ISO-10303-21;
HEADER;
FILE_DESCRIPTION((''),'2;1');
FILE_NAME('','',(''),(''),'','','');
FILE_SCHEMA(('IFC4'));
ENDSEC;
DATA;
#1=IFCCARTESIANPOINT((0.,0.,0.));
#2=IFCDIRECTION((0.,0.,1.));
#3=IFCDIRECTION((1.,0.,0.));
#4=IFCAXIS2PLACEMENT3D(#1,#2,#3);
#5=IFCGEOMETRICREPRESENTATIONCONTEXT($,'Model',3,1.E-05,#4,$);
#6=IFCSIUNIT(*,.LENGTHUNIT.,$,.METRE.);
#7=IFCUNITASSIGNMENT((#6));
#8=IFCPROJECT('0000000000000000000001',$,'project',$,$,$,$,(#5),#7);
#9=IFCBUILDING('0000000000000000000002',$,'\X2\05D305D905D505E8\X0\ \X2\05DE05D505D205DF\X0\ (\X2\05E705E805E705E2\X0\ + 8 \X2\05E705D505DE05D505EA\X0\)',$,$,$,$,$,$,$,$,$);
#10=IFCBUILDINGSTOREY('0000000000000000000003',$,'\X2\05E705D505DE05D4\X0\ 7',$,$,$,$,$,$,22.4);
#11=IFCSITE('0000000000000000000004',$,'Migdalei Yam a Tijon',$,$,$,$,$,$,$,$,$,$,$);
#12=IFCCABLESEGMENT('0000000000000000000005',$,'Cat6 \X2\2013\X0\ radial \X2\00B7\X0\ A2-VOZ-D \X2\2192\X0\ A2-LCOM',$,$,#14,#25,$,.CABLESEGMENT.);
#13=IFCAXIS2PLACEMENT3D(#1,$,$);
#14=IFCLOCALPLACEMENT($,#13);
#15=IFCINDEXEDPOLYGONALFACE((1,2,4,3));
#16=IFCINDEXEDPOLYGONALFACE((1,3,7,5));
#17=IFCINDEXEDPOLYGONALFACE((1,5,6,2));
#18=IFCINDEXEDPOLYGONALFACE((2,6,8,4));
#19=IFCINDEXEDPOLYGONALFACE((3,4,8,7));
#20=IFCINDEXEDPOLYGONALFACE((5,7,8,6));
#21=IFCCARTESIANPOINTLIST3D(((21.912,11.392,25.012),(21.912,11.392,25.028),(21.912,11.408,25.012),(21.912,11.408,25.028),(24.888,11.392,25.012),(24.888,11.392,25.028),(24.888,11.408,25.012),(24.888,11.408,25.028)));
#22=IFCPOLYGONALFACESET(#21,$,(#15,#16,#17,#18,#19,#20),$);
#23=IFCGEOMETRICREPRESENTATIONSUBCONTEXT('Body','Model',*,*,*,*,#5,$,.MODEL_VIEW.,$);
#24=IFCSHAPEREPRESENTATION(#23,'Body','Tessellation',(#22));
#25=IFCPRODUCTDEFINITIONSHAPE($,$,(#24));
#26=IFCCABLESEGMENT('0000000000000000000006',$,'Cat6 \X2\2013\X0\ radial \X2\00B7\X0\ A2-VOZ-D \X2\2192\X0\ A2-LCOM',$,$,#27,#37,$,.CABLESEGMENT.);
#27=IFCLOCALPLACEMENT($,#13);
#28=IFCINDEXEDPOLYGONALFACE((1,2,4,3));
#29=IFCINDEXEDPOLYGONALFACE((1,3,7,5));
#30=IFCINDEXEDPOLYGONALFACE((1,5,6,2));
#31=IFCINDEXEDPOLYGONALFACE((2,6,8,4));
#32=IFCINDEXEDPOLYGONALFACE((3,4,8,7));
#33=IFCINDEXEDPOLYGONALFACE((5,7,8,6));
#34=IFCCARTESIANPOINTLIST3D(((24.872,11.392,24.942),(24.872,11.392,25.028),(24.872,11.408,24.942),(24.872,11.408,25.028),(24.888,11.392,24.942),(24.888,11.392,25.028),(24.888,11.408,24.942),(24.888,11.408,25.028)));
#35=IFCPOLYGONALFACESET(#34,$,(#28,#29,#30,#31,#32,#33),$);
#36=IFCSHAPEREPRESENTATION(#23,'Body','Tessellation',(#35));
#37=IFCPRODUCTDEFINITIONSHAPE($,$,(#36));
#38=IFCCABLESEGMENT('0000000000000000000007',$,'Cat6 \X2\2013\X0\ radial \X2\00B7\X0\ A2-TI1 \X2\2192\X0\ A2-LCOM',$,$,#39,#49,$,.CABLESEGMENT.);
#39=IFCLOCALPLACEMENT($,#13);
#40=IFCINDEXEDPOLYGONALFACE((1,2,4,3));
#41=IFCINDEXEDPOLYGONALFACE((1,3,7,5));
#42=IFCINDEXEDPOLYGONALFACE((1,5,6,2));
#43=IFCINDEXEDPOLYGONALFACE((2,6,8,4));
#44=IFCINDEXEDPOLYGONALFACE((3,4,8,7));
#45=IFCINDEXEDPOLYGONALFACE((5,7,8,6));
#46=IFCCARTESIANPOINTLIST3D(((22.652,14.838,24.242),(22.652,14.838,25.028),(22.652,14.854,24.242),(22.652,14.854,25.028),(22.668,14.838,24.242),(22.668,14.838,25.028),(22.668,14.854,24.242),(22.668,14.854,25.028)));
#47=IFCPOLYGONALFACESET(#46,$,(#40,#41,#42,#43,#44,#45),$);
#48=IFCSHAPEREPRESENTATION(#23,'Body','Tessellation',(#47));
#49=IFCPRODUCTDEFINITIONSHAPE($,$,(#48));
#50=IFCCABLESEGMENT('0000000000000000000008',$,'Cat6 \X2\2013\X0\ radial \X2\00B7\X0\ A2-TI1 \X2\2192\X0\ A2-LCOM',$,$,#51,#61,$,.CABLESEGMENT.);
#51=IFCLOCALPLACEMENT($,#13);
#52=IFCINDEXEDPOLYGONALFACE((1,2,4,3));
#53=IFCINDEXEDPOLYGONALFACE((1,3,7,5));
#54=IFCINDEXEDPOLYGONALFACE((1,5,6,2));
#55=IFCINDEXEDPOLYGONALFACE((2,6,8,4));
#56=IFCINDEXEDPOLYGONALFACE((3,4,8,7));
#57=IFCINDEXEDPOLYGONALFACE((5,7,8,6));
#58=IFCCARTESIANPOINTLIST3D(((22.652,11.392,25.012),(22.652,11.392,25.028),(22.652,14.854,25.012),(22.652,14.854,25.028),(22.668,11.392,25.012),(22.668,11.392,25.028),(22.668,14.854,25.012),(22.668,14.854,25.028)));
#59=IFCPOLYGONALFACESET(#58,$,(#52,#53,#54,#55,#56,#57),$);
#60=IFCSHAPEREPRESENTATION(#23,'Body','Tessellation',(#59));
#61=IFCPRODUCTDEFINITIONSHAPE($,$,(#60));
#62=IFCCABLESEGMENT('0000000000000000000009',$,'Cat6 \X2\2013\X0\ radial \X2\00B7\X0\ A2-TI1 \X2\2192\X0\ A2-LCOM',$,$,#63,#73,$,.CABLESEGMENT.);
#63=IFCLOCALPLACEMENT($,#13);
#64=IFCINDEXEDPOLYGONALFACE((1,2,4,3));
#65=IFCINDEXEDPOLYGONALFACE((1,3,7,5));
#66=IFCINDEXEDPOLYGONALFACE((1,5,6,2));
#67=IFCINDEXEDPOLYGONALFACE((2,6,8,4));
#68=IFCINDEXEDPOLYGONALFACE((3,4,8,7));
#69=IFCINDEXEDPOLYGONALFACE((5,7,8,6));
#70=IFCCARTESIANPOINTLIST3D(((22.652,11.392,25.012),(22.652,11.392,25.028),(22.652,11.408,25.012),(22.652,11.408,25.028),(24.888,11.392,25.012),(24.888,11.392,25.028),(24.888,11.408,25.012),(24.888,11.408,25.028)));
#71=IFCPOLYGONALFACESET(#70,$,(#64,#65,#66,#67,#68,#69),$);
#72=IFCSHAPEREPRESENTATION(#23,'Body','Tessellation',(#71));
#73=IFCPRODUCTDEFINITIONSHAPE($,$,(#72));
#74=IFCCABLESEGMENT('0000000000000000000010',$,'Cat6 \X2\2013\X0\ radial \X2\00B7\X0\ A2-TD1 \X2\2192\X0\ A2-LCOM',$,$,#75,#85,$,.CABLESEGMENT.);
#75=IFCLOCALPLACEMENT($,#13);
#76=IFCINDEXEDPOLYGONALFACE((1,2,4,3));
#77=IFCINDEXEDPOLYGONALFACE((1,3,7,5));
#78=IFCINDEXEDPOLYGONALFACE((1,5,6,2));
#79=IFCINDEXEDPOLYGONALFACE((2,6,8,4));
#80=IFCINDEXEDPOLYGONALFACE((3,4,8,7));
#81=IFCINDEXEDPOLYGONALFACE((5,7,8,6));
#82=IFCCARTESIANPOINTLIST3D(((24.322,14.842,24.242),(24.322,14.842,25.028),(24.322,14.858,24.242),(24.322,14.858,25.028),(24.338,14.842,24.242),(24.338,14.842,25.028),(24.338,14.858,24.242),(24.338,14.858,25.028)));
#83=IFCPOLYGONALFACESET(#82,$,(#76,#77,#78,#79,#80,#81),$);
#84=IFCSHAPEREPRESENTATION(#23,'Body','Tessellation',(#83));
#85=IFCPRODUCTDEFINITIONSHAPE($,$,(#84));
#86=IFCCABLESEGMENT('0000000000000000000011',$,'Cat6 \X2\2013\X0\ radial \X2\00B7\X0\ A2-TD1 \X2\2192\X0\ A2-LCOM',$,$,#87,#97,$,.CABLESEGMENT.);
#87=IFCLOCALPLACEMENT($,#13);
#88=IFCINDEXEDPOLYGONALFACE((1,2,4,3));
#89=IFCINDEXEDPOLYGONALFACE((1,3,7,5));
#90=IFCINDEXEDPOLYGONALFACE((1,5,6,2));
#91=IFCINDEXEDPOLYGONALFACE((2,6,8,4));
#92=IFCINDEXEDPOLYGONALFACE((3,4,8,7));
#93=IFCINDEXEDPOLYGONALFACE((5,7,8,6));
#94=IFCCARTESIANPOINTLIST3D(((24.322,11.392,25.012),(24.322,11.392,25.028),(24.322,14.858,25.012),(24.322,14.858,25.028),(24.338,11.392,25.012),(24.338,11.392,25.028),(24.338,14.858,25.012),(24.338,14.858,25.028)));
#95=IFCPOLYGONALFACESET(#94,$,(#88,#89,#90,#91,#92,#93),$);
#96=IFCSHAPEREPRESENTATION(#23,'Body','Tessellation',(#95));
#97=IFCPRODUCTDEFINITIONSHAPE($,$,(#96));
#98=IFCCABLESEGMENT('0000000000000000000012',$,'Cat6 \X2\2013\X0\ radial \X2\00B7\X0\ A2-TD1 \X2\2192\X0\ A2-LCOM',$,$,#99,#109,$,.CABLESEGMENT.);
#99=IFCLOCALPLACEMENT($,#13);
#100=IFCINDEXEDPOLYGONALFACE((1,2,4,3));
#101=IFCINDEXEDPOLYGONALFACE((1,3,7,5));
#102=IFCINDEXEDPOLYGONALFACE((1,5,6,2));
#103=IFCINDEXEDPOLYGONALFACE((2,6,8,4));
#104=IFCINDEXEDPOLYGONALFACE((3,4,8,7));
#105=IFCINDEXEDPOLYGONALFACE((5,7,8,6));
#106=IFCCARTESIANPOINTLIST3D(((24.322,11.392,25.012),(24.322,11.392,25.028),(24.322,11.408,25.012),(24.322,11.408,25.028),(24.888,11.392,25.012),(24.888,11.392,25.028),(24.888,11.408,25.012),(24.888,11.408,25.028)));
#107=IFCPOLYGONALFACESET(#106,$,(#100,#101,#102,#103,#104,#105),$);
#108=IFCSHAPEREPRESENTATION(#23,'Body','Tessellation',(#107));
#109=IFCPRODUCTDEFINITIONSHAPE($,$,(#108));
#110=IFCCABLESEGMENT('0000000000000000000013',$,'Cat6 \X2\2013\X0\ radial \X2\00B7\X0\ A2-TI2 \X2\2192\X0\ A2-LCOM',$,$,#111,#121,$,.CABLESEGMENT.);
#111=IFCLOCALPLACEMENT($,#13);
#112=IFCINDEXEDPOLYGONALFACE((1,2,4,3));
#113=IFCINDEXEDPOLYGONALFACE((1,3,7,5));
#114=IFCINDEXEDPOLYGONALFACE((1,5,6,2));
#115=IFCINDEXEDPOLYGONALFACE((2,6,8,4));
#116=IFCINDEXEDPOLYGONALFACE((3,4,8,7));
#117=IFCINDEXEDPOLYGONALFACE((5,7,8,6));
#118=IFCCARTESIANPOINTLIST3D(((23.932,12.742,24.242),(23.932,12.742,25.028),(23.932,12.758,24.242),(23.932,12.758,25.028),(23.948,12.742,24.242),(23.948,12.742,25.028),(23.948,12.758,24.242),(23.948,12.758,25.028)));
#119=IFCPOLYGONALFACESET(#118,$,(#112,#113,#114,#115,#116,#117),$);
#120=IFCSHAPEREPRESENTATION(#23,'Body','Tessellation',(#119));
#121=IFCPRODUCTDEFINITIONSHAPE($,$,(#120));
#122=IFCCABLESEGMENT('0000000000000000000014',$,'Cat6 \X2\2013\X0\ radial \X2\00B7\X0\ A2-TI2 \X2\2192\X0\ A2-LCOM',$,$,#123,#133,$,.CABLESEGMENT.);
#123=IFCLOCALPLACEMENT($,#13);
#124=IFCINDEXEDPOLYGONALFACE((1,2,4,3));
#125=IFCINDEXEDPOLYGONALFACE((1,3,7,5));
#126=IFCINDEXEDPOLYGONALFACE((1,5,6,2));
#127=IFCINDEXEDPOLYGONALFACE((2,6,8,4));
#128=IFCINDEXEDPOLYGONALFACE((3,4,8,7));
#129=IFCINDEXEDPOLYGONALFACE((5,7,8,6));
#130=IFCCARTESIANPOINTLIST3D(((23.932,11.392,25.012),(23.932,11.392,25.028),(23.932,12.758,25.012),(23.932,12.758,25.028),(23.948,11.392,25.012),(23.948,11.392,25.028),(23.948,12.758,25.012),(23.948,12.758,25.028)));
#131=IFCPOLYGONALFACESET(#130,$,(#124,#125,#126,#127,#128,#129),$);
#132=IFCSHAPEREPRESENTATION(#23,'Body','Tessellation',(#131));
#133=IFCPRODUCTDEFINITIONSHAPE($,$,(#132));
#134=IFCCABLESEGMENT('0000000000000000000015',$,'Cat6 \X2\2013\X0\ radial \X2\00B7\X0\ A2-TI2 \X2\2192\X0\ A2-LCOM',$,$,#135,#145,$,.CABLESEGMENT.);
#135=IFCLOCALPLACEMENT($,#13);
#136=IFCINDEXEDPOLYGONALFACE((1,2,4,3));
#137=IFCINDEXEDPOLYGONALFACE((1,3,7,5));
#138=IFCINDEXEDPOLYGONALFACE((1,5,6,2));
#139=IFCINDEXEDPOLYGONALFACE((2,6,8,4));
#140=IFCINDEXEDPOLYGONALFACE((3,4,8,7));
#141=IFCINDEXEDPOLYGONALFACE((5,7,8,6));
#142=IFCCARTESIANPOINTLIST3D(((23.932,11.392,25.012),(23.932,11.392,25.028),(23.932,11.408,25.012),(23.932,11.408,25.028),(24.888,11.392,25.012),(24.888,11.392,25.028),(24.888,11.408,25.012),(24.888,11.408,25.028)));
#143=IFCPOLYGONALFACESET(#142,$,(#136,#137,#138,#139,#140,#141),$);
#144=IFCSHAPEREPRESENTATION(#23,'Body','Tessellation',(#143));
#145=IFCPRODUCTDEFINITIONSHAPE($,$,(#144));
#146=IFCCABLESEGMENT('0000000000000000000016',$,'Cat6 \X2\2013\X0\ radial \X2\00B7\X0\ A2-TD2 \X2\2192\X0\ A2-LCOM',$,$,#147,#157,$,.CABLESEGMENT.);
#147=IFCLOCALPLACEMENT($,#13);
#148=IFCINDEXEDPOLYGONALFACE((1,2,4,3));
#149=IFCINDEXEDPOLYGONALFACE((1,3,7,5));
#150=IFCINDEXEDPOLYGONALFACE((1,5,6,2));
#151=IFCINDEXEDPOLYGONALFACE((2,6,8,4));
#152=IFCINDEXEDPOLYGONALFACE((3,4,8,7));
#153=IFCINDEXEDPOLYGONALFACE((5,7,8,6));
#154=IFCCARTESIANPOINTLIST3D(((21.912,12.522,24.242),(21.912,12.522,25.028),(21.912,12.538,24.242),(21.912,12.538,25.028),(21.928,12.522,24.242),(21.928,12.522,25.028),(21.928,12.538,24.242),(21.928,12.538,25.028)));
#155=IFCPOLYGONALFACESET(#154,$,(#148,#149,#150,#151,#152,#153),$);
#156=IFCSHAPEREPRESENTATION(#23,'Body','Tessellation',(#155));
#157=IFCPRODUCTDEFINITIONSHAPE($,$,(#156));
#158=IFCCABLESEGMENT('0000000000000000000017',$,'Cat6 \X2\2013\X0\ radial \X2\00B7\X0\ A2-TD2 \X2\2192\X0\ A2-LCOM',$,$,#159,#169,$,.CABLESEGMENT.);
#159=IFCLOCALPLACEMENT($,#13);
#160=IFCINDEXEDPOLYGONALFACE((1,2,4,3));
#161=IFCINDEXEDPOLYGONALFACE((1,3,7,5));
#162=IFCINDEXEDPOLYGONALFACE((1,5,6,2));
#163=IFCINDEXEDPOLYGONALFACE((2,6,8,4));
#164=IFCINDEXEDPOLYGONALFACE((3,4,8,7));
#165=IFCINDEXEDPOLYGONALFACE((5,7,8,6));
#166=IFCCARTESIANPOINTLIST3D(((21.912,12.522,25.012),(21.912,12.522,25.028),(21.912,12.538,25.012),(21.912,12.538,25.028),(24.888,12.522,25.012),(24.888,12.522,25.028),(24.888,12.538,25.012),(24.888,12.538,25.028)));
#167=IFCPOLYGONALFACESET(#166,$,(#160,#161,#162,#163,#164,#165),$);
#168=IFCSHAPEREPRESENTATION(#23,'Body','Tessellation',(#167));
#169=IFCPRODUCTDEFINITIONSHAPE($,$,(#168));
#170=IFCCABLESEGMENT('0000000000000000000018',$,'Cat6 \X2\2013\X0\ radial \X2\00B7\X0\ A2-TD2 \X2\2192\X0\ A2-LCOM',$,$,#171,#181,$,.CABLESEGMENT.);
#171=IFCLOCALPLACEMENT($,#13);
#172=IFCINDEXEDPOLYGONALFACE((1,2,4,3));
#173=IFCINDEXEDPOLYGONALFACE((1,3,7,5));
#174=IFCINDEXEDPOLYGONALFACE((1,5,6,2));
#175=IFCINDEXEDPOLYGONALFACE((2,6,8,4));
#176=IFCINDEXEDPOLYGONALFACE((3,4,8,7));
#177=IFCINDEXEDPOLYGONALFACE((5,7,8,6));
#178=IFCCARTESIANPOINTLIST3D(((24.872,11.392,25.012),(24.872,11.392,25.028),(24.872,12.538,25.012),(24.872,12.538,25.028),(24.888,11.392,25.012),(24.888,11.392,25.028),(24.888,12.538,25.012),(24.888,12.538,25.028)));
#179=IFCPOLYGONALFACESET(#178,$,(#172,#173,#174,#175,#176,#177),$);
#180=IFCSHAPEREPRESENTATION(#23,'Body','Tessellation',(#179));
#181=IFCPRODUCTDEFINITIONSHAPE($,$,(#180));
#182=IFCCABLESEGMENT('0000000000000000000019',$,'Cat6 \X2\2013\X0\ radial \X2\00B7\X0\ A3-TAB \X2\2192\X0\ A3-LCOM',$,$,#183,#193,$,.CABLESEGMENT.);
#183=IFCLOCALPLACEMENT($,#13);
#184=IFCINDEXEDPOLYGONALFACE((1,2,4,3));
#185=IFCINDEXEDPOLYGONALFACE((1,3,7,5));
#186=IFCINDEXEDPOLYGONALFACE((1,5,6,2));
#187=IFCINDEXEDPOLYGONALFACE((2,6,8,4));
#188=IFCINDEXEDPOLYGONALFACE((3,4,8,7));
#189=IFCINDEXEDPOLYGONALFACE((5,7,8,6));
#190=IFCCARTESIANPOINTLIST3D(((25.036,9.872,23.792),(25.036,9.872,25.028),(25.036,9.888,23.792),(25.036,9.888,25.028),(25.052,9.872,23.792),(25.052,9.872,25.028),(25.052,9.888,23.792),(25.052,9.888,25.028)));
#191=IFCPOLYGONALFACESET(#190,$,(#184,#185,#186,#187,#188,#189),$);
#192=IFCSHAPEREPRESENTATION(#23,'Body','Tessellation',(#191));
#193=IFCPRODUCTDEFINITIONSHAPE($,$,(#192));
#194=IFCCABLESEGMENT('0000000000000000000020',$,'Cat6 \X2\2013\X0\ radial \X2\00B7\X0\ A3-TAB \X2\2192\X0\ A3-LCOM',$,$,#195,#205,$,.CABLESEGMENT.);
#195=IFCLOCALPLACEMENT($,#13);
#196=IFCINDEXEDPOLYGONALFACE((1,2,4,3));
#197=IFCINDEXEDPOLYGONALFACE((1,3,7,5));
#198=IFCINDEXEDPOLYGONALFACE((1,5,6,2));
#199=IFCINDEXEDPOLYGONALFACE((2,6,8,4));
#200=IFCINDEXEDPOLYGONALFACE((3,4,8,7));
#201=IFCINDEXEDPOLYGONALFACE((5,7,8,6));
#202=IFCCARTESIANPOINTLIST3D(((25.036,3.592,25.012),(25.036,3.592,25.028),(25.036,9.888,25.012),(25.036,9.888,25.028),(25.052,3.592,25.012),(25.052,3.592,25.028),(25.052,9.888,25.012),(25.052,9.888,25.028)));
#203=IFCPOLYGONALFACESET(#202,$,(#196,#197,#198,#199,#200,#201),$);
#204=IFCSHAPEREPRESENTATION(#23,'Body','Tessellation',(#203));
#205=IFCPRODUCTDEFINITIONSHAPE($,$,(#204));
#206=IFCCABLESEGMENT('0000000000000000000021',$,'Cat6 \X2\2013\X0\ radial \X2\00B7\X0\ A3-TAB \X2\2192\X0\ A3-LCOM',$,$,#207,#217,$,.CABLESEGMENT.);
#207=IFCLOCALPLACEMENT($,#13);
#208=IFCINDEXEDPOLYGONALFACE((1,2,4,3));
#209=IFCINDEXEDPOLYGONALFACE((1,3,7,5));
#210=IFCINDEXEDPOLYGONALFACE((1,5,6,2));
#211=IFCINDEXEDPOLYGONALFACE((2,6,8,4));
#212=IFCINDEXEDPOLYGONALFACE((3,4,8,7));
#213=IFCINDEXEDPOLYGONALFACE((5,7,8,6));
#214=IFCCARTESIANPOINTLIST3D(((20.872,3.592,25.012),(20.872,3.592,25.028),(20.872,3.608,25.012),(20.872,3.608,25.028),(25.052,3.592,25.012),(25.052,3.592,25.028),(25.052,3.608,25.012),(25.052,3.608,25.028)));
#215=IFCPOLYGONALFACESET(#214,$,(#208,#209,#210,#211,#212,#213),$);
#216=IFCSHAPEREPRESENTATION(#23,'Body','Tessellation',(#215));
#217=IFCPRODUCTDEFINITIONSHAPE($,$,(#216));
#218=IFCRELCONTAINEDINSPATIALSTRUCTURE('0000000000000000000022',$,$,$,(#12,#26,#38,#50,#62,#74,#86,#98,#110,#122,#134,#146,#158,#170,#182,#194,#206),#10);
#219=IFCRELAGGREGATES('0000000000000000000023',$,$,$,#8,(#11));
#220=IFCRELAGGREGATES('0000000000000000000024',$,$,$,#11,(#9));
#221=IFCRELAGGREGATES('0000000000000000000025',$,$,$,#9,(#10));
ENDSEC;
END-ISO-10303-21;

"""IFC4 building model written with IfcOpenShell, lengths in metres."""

from ifc_helpers import new_model, si_unit, frame, origin_with_axes, context, subcontext, project, spatial, line, indexed_curve, outline, extrude, element, save


model = new_model("IFC4")

# Units and contexts
model_context = context("Model", 3, precision=1e-05, world=origin_with_axes())
body_context = subcontext(model_context, "Body", "Model", "MODEL_VIEW")
ifc_project = project(units=[si_unit("LENGTHUNIT", "METRE")], contexts=[model_context])

# Site, building, storey
site = spatial("IfcSite", under=ifc_project, Name="Migdalei Yam a Tijon")
building = spatial("IfcBuilding", under=site, Name="דיור מוגן (קרקע + 8 קומות)")
storey = spatial("IfcBuildingStorey", under=building, Name="קומה 7", Elevation=22.4)

# Cable segments
element("IfcCableSegment", 1, inside=storey, Name="Cat6 – radial · A2-VOZ-D → A2-LCOM", PredefinedType="CABLESEGMENT", context=body_context, shape_type="SweptSolid", body=[
    extrude(outline(indexed_curve([(0.0, 0.0), (2.976, 0.0), (2.976, 0.016), (0.0, 0.016)], segments=[line(1, 2, 3, 4, 1)])), frame((21.912, 11.392, 25.012), z_axis=(0.0, 0.0, 1.0), x_axis=(1.0, 0.0, 0.0)), (0.0, 0.0, 1.0), 0.016),
])
element("IfcCableSegment", 2, inside=storey, Name="Cat6 – radial · A2-VOZ-D → A2-LCOM", PredefinedType="CABLESEGMENT", context=body_context, shape_type="SweptSolid", body=[
    extrude(outline(indexed_curve([(0.0, 0.0), (0.016, 0.0), (0.016, 0.016), (0.0, 0.016)], segments=[line(1, 2, 3, 4, 1)])), frame((24.872, 11.392, 24.942), z_axis=(0.0, 0.0, 1.0), x_axis=(1.0, 0.0, 0.0)), (0.0, 0.0, 1.0), 0.086),
])
element("IfcCableSegment", 3, inside=storey, Name="Cat6 – radial · A2-TI1 → A2-LCOM", PredefinedType="CABLESEGMENT", context=body_context, shape_type="SweptSolid", body=[
    extrude(outline(indexed_curve([(0.0, 0.0), (0.016, 0.0), (0.016, 0.016), (0.0, 0.016)], segments=[line(1, 2, 3, 4, 1)])), frame((22.652, 14.838, 24.242), z_axis=(0.0, 0.0, 1.0), x_axis=(1.0, 0.0, 0.0)), (0.0, 0.0, 1.0), 0.786),
])
element("IfcCableSegment", 4, inside=storey, Name="Cat6 – radial · A2-TI1 → A2-LCOM", PredefinedType="CABLESEGMENT", context=body_context, shape_type="SweptSolid", body=[
    extrude(outline(indexed_curve([(0.0, 0.0), (0.016, 0.0), (0.016, 3.462), (0.0, 3.462)], segments=[line(1, 2, 3, 4, 1)])), frame((22.652, 11.392, 25.012), z_axis=(0.0, 0.0, 1.0), x_axis=(1.0, 0.0, 0.0)), (0.0, 0.0, 1.0), 0.016),
])
element("IfcCableSegment", 5, inside=storey, Name="Cat6 – radial · A2-TI1 → A2-LCOM", PredefinedType="CABLESEGMENT", context=body_context, shape_type="SweptSolid", body=[
    extrude(outline(indexed_curve([(0.0, 0.0), (2.236, 0.0), (2.236, 0.016), (0.0, 0.016)], segments=[line(1, 2, 3, 4, 1)])), frame((22.652, 11.392, 25.012), z_axis=(0.0, 0.0, 1.0), x_axis=(1.0, 0.0, 0.0)), (0.0, 0.0, 1.0), 0.016),
])
element("IfcCableSegment", 6, inside=storey, Name="Cat6 – radial · A2-TD1 → A2-LCOM", PredefinedType="CABLESEGMENT", context=body_context, shape_type="SweptSolid", body=[
    extrude(outline(indexed_curve([(0.0, 0.0), (0.016, 0.0), (0.016, 0.016), (0.0, 0.016)], segments=[line(1, 2, 3, 4, 1)])), frame((24.322, 14.842, 24.242), z_axis=(0.0, 0.0, 1.0), x_axis=(1.0, 0.0, 0.0)), (0.0, 0.0, 1.0), 0.786),
])
element("IfcCableSegment", 7, inside=storey, Name="Cat6 – radial · A2-TD1 → A2-LCOM", PredefinedType="CABLESEGMENT", context=body_context, shape_type="SweptSolid", body=[
    extrude(outline(indexed_curve([(0.0, 0.0), (0.016, 0.0), (0.016, 3.466), (0.0, 3.466)], segments=[line(1, 2, 3, 4, 1)])), frame((24.322, 11.392, 25.012), z_axis=(0.0, 0.0, 1.0), x_axis=(1.0, 0.0, 0.0)), (0.0, 0.0, 1.0), 0.016),
])
element("IfcCableSegment", 8, inside=storey, Name="Cat6 – radial · A2-TD1 → A2-LCOM", PredefinedType="CABLESEGMENT", context=body_context, shape_type="SweptSolid", body=[
    extrude(outline(indexed_curve([(0.0, 0.0), (0.566, 0.0), (0.566, 0.016), (0.0, 0.016)], segments=[line(1, 2, 3, 4, 1)])), frame((24.322, 11.392, 25.012), z_axis=(0.0, 0.0, 1.0), x_axis=(1.0, 0.0, 0.0)), (0.0, 0.0, 1.0), 0.016),
])
element("IfcCableSegment", 9, inside=storey, Name="Cat6 – radial · A2-TI2 → A2-LCOM", PredefinedType="CABLESEGMENT", context=body_context, shape_type="SweptSolid", body=[
    extrude(outline(indexed_curve([(0.0, 0.0), (0.016, 0.0), (0.016, 0.016), (0.0, 0.016)], segments=[line(1, 2, 3, 4, 1)])), frame((23.932, 12.742, 24.242), z_axis=(0.0, 0.0, 1.0), x_axis=(1.0, 0.0, 0.0)), (0.0, 0.0, 1.0), 0.786),
])
element("IfcCableSegment", 10, inside=storey, Name="Cat6 – radial · A2-TI2 → A2-LCOM", PredefinedType="CABLESEGMENT", context=body_context, shape_type="SweptSolid", body=[
    extrude(outline(indexed_curve([(0.0, 0.0), (0.016, 0.0), (0.016, 1.366), (0.0, 1.366)], segments=[line(1, 2, 3, 4, 1)])), frame((23.932, 11.392, 25.012), z_axis=(0.0, 0.0, 1.0), x_axis=(1.0, 0.0, 0.0)), (0.0, 0.0, 1.0), 0.016),
])
element("IfcCableSegment", 11, inside=storey, Name="Cat6 – radial · A2-TI2 → A2-LCOM", PredefinedType="CABLESEGMENT", context=body_context, shape_type="SweptSolid", body=[
    extrude(outline(indexed_curve([(0.0, 0.0), (0.956, 0.0), (0.956, 0.016), (0.0, 0.016)], segments=[line(1, 2, 3, 4, 1)])), frame((23.932, 11.392, 25.012), z_axis=(0.0, 0.0, 1.0), x_axis=(1.0, 0.0, 0.0)), (0.0, 0.0, 1.0), 0.016),
])
element("IfcCableSegment", 12, inside=storey, Name="Cat6 – radial · A2-TD2 → A2-LCOM", PredefinedType="CABLESEGMENT", context=body_context, shape_type="SweptSolid", body=[
    extrude(outline(indexed_curve([(0.0, 0.0), (0.016, 0.0), (0.016, 0.016), (0.0, 0.016)], segments=[line(1, 2, 3, 4, 1)])), frame((21.912, 12.522, 24.242), z_axis=(0.0, 0.0, 1.0), x_axis=(1.0, 0.0, 0.0)), (0.0, 0.0, 1.0), 0.786),
])
element("IfcCableSegment", 13, inside=storey, Name="Cat6 – radial · A2-TD2 → A2-LCOM", PredefinedType="CABLESEGMENT", context=body_context, shape_type="SweptSolid", body=[
    extrude(outline(indexed_curve([(0.0, 0.0), (2.976, 0.0), (2.976, 0.016), (0.0, 0.016)], segments=[line(1, 2, 3, 4, 1)])), frame((21.912, 12.522, 25.012), z_axis=(0.0, 0.0, 1.0), x_axis=(1.0, 0.0, 0.0)), (0.0, 0.0, 1.0), 0.016),
])
element("IfcCableSegment", 14, inside=storey, Name="Cat6 – radial · A2-TD2 → A2-LCOM", PredefinedType="CABLESEGMENT", context=body_context, shape_type="SweptSolid", body=[
    extrude(outline(indexed_curve([(0.0, 0.0), (0.016, 0.0), (0.016, 1.146), (0.0, 1.146)], segments=[line(1, 2, 3, 4, 1)])), frame((24.872, 11.392, 25.012), z_axis=(0.0, 0.0, 1.0), x_axis=(1.0, 0.0, 0.0)), (0.0, 0.0, 1.0), 0.016),
])
element("IfcCableSegment", 15, inside=storey, Name="Cat6 – radial · A3-TAB → A3-LCOM", PredefinedType="CABLESEGMENT", context=body_context, shape_type="SweptSolid", body=[
    extrude(outline(indexed_curve([(0.0, 0.0), (0.016, 0.0), (0.016, 0.016), (0.0, 0.016)], segments=[line(1, 2, 3, 4, 1)])), frame((25.036, 9.872, 23.792), z_axis=(0.0, 0.0, 1.0), x_axis=(1.0, 0.0, 0.0)), (0.0, 0.0, 1.0), 1.236),
])
element("IfcCableSegment", 16, inside=storey, Name="Cat6 – radial · A3-TAB → A3-LCOM", PredefinedType="CABLESEGMENT", context=body_context, shape_type="SweptSolid", body=[
    extrude(outline(indexed_curve([(0.0, 0.0), (0.016, 0.0), (0.016, 6.296), (0.0, 6.296)], segments=[line(1, 2, 3, 4, 1)])), frame((25.036, 3.592, 25.012), z_axis=(0.0, 0.0, 1.0), x_axis=(1.0, 0.0, 0.0)), (0.0, 0.0, 1.0), 0.016),
])
element("IfcCableSegment", 17, inside=storey, Name="Cat6 – radial · A3-TAB → A3-LCOM", PredefinedType="CABLESEGMENT", context=body_context, shape_type="SweptSolid", body=[
    extrude(outline(indexed_curve([(0.0, 0.0), (4.18, 0.0), (4.18, 0.016), (0.0, 0.016)], segments=[line(1, 2, 3, 4, 1)])), frame((20.872, 3.592, 25.012), z_axis=(0.0, 0.0, 1.0), x_axis=(1.0, 0.0, 0.0)), (0.0, 0.0, 1.0), 0.016),
])

save(model, "model.ifc")
